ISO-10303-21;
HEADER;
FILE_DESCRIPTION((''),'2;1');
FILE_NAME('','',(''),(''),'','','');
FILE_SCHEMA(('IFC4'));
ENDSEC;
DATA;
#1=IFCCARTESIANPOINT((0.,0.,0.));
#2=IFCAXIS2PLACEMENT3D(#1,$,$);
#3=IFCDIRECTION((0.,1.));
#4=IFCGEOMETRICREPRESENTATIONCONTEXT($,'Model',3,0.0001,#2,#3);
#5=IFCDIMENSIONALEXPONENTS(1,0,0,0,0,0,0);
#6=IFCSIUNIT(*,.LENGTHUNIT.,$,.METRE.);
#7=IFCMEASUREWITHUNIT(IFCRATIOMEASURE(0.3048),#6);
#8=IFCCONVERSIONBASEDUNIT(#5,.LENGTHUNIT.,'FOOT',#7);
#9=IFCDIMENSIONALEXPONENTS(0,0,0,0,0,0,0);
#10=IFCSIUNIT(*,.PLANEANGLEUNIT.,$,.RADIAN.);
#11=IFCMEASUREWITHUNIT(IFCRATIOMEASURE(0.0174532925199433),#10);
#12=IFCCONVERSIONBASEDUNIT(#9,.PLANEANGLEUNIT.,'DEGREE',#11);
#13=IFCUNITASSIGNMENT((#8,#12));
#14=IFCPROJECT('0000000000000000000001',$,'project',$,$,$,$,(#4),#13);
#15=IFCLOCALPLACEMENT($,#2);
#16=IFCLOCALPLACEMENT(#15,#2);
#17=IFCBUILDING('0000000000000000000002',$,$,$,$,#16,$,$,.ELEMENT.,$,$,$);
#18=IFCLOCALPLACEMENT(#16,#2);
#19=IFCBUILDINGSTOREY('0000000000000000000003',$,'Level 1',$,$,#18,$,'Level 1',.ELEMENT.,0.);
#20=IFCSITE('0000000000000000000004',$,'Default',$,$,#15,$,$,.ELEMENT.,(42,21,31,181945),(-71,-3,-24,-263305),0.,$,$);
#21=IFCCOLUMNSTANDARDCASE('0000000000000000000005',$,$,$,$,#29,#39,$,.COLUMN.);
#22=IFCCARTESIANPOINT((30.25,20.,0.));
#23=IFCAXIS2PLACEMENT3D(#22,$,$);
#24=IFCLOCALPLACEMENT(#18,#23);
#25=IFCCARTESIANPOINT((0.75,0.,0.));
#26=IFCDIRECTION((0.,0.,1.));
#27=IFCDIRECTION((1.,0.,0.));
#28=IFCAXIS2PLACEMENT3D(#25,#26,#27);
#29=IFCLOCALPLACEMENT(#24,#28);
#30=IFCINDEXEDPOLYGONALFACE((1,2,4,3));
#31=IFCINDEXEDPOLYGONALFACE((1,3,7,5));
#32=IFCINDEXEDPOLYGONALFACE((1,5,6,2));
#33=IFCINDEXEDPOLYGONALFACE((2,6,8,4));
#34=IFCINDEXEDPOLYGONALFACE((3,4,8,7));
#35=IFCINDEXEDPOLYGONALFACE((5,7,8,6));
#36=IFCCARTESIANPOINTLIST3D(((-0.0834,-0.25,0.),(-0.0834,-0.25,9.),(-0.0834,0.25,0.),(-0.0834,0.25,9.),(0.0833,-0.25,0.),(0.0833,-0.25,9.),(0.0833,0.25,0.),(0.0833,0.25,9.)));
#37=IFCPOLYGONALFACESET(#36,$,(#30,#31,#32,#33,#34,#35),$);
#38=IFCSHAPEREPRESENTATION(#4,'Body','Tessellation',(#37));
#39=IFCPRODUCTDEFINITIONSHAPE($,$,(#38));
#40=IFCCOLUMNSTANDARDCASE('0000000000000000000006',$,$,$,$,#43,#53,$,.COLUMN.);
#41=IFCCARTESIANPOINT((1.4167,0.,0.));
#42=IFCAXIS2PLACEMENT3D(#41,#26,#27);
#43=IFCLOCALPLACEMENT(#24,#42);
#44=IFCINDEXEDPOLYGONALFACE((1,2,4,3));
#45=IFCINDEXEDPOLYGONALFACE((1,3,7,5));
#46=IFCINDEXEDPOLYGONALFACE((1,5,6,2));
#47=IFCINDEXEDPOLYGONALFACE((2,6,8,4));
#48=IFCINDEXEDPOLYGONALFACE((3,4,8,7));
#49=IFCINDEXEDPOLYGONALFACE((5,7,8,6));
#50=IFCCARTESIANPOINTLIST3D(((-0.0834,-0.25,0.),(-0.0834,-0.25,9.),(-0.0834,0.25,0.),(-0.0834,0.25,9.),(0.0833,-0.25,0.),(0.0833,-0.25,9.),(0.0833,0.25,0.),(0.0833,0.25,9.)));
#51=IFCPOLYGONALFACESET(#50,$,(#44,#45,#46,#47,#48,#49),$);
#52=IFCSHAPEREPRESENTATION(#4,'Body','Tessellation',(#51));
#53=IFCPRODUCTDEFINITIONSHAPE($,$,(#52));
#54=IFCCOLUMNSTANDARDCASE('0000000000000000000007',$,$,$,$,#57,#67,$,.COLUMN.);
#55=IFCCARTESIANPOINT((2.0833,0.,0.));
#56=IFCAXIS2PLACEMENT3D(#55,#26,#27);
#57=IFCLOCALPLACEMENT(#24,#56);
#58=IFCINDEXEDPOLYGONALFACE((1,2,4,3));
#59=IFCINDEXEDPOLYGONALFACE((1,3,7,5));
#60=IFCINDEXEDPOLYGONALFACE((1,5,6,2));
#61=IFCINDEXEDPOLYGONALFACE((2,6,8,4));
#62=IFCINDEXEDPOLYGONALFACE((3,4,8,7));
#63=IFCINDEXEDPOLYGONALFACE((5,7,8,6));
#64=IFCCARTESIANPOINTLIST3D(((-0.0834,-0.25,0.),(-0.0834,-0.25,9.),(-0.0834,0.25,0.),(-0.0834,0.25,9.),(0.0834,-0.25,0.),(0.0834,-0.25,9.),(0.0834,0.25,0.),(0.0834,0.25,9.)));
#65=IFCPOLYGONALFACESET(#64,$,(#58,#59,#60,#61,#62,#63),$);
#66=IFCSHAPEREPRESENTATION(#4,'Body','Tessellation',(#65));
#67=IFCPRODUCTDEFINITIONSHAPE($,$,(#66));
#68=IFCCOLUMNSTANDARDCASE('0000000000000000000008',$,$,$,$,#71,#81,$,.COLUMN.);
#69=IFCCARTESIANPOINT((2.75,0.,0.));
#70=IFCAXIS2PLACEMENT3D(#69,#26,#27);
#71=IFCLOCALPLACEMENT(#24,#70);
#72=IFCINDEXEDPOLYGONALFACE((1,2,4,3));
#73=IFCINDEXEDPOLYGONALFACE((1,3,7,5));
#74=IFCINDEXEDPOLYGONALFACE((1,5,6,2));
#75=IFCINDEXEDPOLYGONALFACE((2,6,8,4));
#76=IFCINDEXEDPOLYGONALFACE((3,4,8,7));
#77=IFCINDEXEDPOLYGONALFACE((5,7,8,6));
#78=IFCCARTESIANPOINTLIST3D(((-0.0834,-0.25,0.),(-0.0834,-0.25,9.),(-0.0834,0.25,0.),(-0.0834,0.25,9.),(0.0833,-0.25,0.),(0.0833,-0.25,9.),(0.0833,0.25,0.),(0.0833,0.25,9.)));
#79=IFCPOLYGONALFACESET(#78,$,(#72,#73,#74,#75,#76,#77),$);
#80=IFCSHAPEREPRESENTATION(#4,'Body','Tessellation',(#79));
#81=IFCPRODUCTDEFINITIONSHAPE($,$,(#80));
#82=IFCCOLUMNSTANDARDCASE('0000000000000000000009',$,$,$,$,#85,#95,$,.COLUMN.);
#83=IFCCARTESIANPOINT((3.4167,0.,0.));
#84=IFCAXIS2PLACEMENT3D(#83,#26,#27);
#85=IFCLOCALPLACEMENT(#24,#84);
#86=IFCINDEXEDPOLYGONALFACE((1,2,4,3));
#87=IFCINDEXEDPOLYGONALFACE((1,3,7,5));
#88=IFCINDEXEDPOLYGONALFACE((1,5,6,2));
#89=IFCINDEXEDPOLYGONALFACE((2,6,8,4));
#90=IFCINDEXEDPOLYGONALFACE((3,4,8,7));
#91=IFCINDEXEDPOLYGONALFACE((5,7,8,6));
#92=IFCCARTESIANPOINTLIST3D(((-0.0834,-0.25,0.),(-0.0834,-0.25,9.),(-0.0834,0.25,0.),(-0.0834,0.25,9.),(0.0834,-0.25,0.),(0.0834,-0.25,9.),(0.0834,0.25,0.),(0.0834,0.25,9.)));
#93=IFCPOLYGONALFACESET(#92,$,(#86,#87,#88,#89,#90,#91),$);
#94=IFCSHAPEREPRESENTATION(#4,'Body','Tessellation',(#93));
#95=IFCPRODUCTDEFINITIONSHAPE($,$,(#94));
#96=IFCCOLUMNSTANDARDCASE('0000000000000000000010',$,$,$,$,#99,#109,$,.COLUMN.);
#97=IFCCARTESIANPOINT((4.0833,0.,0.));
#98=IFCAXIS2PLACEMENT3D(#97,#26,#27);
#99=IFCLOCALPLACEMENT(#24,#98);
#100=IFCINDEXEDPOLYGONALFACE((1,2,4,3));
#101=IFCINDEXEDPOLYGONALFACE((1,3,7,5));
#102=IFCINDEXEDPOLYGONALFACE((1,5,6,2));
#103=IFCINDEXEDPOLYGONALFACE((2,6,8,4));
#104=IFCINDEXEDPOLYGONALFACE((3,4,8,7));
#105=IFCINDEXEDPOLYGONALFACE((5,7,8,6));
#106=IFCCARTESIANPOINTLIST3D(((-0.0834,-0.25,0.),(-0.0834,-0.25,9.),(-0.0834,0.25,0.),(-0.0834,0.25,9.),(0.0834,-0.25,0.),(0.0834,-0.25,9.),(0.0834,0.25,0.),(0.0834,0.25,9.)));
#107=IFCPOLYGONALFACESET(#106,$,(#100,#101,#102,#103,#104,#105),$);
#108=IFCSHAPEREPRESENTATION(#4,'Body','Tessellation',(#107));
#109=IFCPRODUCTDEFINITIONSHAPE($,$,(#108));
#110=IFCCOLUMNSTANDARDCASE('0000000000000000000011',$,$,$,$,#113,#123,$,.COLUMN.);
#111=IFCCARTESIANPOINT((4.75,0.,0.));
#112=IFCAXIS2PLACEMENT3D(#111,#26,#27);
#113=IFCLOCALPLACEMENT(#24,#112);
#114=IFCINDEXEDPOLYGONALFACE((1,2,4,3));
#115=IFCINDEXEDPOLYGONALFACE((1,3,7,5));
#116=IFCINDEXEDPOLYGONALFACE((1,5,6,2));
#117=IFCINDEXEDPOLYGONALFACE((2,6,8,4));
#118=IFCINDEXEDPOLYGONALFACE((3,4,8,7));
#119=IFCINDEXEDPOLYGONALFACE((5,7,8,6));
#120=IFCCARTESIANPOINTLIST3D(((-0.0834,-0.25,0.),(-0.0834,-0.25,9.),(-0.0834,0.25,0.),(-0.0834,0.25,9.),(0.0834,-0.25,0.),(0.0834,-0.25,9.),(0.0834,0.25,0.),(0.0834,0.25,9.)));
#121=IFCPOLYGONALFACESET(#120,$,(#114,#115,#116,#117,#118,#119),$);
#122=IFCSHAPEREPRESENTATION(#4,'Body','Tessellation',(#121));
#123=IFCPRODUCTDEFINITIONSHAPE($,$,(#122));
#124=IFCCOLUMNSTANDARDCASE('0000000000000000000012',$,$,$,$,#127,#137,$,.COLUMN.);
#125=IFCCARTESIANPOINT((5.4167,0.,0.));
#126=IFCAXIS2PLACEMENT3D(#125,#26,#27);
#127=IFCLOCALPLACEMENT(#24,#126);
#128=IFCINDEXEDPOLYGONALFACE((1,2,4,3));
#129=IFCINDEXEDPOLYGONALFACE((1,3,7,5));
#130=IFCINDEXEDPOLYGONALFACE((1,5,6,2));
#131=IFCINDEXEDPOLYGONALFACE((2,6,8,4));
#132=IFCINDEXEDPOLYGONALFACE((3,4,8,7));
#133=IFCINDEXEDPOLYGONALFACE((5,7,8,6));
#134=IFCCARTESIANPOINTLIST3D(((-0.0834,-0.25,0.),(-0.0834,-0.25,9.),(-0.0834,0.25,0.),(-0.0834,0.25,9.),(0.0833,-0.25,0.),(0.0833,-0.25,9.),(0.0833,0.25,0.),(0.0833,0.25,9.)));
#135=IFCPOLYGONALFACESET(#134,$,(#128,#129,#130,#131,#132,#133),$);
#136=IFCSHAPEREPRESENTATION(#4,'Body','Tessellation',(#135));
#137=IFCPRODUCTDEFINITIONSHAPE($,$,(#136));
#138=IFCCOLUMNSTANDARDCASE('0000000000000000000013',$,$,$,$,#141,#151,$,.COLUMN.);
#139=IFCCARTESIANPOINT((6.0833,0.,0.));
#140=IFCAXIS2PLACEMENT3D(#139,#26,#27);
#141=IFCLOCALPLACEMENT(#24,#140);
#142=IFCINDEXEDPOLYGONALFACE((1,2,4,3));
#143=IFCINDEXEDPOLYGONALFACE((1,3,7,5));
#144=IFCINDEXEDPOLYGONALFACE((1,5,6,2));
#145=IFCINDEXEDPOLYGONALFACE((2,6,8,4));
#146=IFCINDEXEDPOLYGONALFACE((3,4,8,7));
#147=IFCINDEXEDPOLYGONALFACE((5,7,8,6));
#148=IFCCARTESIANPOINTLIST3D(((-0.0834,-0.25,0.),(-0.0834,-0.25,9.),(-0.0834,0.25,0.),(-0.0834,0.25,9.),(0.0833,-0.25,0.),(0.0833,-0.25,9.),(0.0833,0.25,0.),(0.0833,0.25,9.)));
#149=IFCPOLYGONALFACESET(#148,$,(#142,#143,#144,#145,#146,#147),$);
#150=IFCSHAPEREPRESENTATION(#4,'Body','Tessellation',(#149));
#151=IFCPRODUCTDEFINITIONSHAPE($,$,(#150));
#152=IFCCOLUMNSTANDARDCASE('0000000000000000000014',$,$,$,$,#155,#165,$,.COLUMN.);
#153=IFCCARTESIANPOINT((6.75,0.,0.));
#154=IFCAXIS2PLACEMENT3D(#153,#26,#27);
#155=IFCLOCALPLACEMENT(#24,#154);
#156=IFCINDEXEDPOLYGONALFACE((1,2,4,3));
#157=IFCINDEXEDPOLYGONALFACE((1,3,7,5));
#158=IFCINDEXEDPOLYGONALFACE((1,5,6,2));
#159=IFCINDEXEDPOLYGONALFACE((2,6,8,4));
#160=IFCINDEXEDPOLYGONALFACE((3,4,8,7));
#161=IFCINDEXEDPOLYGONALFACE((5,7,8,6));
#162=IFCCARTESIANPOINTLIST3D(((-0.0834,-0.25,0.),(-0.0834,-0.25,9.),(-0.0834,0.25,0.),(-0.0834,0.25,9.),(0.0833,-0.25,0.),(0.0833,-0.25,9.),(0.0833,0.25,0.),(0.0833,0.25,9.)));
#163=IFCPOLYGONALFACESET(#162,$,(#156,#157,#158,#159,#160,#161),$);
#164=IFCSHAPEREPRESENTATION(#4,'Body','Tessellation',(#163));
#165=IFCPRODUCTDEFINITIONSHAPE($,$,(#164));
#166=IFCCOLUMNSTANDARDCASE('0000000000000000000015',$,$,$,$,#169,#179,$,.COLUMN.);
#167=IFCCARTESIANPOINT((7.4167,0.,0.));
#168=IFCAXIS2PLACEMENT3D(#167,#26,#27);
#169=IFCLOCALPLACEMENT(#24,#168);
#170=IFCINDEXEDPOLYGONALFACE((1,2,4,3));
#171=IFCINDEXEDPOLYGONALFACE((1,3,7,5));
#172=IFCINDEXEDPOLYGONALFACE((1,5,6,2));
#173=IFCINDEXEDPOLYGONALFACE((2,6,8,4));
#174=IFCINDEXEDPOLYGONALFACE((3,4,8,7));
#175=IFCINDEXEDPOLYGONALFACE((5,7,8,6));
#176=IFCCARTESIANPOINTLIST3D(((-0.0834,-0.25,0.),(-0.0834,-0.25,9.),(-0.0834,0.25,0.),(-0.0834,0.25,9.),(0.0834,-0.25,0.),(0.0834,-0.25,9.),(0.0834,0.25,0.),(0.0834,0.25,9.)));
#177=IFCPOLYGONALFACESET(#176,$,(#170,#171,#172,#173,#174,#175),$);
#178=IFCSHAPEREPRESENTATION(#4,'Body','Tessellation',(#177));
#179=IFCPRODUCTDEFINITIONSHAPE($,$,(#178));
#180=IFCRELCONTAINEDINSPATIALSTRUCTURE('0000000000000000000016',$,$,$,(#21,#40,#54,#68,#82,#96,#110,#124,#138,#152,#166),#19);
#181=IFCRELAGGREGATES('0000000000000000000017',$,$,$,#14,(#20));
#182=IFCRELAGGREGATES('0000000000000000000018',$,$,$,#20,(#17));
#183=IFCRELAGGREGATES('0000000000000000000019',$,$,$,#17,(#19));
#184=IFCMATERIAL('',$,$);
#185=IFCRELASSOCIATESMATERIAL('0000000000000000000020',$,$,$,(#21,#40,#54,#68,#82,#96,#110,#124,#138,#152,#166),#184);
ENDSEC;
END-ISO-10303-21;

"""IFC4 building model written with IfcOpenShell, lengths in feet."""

from ifc_helpers import new_model, entity, si_unit, converted_unit, direction, frame, origin, place, context, project, spatial, rectangle, extrude, material, element, save


model = new_model("IFC4")

# Units and contexts
model_context = context("Model", 3, precision=0.0001, world=origin(), true_north=direction((0.0, 1.0)))
ifc_project = project(units=[converted_unit("LENGTHUNIT", "FOOT", entity("IfcRatioMeasure", 0.3048), si_unit("LENGTHUNIT", "METRE"), dimensions=[1, 0, 0, 0, 0, 0, 0]), converted_unit("PLANEANGLEUNIT", "DEGREE", entity("IfcRatioMeasure", 0.0174532925199433), si_unit("PLANEANGLEUNIT", "RADIAN"), dimensions=[0, 0, 0, 0, 0, 0, 0])], contexts=[model_context])

# Site, building, storey
site_placement = place(None, origin())
site = spatial("IfcSite", under=ifc_project, at=site_placement, Name="Default", CompositionType="ELEMENT", RefLatitude=(42, 21, 31, 181945), RefLongitude=(-71, -3, -24, -263305), RefElevation=0.0)
building_placement = place(site_placement, origin())
building = spatial("IfcBuilding", under=site, at=building_placement, CompositionType="ELEMENT")
storey_placement = place(building_placement, origin())
storey = spatial("IfcBuildingStorey", under=building, at=storey_placement, Name="Level 1", LongName="Level 1", CompositionType="ELEMENT", Elevation=0.0)

# Columns
ifc_material_1 = material(Name="")
wall_placement = place(storey_placement, frame((30.25, 20.0, 0.0)))
for number, where, z_axis, x_axis in (
    (1, (0.75, 0.0, 0.0), (0.0, 0.0, 1.0), (1.0, 0.0, 0.0)),
    (2, (1.4167, 0.0, 0.0), (0.0, 0.0, 1.0), (1.0, 0.0, 0.0)),
    (3, (2.0833, 0.0, 0.0), (0.0, 0.0, 1.0), (1.0, 0.0, 0.0)),
    (4, (2.75, 0.0, 0.0), (0.0, 0.0, 1.0), (1.0, 0.0, 0.0)),
    (5, (3.4167, 0.0, 0.0), (0.0, 0.0, 1.0), (1.0, 0.0, 0.0)),
    (6, (4.0833, 0.0, 0.0), (0.0, 0.0, 1.0), (1.0, 0.0, 0.0)),
    (7, (4.75, 0.0, 0.0), (0.0, 0.0, 1.0), (1.0, 0.0, 0.0)),
    (8, (5.4167, 0.0, 0.0), (0.0, 0.0, 1.0), (1.0, 0.0, 0.0)),
    (9, (6.0833, 0.0, 0.0), (0.0, 0.0, 1.0), (1.0, 0.0, 0.0)),
    (10, (6.75, 0.0, 0.0), (0.0, 0.0, 1.0), (1.0, 0.0, 0.0)),
    (11, (7.4167, 0.0, 0.0), (0.0, 0.0, 1.0), (1.0, 0.0, 0.0)),
):
    element("IfcColumnStandardCase", number, at=place(wall_placement, frame(where, z_axis=z_axis, x_axis=x_axis)), inside=storey, material=ifc_material_1, PredefinedType="COLUMN", context=model_context, shape_type="SweptSolid", body=[
        extrude(rectangle(XDim=0.1667, YDim=0.5), origin(), (0.0, 0.0, 1.0), 9.0),
    ])

save(model, "model.ifc")
